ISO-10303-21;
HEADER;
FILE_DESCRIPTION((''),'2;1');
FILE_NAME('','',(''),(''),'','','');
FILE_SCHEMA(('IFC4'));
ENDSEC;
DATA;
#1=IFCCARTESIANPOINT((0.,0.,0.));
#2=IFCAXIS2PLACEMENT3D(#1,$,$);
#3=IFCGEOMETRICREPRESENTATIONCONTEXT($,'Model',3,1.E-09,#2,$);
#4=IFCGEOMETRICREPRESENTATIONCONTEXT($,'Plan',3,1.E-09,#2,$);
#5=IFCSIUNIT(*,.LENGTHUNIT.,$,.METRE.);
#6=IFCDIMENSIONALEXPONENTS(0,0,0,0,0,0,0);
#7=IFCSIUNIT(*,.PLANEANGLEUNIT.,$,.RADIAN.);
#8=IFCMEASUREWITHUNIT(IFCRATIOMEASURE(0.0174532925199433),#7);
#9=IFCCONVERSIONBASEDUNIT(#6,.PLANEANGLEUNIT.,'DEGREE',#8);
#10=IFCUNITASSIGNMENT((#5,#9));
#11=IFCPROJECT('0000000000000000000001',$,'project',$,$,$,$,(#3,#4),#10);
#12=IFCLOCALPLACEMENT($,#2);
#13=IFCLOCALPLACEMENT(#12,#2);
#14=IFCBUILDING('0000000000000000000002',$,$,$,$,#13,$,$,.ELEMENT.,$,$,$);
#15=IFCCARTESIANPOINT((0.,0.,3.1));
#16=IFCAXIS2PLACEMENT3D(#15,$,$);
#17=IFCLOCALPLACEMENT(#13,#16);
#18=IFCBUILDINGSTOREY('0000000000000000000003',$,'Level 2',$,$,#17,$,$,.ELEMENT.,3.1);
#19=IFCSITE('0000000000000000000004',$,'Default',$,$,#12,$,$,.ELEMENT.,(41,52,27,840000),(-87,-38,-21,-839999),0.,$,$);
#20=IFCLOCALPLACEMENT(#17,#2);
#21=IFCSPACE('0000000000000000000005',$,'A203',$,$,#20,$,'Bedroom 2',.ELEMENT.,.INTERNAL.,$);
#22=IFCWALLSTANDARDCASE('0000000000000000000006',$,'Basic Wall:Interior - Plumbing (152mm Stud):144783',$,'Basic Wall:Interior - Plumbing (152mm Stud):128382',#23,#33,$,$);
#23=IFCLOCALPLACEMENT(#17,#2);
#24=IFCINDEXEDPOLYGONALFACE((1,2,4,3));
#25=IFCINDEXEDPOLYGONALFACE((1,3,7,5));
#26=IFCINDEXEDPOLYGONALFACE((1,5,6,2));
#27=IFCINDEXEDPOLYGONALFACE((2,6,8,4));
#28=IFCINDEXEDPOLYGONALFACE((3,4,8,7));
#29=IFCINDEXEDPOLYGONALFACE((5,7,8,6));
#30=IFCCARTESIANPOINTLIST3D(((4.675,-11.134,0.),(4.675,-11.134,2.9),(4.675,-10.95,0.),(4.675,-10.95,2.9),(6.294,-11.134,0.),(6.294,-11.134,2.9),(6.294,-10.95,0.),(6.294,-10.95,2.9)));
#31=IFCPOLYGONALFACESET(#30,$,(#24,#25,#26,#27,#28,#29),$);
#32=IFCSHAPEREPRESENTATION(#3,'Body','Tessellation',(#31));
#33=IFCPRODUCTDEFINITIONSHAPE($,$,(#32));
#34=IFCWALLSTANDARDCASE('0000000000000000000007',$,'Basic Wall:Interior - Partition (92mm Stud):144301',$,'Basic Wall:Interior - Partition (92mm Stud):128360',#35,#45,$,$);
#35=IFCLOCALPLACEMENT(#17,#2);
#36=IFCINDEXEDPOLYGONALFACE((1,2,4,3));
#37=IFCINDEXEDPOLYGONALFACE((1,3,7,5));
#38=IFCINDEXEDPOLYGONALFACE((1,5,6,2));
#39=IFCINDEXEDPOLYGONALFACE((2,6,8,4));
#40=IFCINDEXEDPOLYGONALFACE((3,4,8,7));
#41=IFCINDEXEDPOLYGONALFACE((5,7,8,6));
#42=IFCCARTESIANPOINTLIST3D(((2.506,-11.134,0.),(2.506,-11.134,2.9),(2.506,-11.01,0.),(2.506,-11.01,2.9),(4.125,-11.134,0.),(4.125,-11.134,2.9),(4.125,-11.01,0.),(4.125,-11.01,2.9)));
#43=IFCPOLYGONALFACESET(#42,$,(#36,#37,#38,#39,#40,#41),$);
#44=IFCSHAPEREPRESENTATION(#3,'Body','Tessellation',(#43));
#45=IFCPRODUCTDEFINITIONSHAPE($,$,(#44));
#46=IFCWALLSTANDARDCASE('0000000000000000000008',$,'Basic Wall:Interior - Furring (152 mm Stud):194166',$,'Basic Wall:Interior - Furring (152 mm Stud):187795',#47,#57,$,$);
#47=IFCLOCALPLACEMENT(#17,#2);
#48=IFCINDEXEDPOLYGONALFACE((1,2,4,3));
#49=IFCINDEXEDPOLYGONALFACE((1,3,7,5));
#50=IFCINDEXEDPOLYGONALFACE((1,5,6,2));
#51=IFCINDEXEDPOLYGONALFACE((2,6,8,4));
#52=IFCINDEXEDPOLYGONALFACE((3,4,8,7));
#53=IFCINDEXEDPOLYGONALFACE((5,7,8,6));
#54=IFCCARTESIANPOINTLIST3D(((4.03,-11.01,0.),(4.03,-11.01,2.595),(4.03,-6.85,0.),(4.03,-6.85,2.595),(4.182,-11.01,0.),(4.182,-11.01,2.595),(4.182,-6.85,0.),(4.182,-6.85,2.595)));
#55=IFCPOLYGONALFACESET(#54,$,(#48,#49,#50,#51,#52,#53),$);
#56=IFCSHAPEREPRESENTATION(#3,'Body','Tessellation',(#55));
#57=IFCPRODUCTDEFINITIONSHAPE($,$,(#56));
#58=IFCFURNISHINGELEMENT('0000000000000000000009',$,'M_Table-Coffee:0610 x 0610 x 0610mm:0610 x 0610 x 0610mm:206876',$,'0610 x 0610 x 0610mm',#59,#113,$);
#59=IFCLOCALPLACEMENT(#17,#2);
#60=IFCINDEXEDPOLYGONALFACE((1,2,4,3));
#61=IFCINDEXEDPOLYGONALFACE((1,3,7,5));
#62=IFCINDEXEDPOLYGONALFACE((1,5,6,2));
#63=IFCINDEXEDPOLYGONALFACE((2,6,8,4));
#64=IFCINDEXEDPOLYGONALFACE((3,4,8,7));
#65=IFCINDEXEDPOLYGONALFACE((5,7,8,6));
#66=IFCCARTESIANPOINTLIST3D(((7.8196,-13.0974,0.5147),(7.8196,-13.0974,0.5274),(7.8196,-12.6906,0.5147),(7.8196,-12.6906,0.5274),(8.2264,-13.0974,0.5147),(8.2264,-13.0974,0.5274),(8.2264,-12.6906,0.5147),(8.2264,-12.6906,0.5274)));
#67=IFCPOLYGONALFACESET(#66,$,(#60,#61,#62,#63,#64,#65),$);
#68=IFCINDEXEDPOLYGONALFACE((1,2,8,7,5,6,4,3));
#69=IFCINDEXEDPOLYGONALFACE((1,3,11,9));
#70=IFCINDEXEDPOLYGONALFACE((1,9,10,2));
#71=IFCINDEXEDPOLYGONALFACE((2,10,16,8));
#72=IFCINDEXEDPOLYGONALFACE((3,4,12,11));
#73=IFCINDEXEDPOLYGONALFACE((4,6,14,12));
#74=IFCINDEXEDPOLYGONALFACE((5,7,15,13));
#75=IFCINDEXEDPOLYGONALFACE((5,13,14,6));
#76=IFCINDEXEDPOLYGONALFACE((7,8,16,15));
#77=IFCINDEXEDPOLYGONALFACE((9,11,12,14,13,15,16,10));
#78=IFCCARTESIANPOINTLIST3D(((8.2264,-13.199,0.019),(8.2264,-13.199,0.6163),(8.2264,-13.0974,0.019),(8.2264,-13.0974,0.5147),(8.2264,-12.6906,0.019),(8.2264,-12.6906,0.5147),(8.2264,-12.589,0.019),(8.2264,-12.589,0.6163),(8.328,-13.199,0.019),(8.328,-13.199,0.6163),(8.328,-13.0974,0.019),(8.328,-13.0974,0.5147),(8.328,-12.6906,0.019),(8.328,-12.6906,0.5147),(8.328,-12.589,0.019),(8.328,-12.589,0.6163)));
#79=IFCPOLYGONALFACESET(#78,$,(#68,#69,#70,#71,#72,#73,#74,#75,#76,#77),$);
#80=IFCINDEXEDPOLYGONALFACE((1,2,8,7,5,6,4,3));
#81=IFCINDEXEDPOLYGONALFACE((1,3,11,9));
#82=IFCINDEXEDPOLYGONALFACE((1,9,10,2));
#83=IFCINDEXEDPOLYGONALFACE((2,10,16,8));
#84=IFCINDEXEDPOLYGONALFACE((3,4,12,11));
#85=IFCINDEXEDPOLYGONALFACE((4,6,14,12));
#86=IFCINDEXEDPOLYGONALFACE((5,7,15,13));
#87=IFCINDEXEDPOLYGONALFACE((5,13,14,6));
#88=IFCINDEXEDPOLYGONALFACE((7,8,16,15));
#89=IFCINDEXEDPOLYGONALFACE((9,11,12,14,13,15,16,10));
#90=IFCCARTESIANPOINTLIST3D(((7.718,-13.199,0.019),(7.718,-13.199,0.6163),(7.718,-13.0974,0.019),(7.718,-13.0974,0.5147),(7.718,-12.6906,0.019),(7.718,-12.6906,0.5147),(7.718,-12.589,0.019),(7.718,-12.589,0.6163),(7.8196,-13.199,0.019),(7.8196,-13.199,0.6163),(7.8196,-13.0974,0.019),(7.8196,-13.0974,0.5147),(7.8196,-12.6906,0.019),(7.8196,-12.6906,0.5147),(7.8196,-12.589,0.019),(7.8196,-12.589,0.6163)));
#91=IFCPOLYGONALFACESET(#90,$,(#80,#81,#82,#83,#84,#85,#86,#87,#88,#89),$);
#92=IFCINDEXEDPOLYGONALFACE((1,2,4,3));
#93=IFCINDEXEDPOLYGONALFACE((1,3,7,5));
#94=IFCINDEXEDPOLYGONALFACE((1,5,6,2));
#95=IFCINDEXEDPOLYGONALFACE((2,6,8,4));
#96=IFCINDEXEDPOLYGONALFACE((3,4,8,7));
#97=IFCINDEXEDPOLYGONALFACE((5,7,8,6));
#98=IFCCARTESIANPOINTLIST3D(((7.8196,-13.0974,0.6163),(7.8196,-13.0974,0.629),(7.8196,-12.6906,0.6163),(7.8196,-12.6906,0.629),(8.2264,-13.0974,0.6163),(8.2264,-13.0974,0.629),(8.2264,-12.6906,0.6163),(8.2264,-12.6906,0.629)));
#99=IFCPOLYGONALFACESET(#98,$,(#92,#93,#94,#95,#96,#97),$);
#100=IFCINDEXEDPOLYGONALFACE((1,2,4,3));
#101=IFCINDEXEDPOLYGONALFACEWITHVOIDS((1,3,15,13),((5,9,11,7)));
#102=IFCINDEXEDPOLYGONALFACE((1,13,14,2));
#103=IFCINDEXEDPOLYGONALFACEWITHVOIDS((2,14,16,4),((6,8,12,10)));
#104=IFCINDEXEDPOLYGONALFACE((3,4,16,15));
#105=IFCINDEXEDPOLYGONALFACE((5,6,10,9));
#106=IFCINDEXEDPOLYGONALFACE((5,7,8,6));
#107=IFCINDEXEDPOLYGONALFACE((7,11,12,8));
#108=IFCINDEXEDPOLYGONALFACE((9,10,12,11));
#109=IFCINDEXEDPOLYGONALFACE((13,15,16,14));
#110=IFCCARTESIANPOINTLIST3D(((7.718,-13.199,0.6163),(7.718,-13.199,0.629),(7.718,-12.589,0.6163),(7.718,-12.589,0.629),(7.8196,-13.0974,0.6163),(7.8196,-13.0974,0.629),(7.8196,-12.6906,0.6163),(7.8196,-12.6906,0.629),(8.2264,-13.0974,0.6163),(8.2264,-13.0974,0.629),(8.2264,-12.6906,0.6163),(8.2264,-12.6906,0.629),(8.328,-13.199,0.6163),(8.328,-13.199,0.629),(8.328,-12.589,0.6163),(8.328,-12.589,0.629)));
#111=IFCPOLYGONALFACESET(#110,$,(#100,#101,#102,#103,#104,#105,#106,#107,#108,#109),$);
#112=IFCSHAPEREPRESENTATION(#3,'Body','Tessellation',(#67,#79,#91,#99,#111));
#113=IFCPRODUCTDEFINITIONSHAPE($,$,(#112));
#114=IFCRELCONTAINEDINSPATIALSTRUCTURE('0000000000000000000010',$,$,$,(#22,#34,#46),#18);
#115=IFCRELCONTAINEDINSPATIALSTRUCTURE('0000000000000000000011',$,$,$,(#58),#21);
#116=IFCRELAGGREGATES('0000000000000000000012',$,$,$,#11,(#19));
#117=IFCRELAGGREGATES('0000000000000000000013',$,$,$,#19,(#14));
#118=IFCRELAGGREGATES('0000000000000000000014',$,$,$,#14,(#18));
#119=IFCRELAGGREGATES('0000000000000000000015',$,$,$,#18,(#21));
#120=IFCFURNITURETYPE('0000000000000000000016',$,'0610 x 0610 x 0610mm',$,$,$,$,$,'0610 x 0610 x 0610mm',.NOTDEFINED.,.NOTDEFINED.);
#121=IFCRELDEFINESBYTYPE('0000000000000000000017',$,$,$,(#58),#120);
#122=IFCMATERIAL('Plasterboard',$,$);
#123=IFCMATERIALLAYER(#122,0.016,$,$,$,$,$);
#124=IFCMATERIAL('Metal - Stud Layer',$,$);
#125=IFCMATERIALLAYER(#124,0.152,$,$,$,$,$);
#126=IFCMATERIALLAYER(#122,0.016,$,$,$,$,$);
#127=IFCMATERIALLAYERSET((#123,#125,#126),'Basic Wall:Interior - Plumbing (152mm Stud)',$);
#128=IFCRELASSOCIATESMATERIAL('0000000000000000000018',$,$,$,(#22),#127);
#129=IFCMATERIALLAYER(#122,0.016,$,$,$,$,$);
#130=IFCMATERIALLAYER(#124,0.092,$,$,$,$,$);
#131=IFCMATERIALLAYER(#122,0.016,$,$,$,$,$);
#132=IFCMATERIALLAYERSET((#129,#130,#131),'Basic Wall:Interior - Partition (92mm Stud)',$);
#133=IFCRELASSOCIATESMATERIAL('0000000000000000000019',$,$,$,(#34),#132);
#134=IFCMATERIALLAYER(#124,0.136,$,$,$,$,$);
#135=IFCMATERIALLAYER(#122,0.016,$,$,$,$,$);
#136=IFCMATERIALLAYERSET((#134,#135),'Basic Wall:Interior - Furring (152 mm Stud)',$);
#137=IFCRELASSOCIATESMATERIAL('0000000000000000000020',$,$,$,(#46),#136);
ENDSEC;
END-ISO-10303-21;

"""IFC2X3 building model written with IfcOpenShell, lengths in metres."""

from ifc_helpers import new_model, entity, si_unit, converted_unit, frame, frame_2d, origin, origin_2d_with_axis, place, context, project, spatial, polyline, rectangle, outline, extrude, source, transform, mapped, material, layer, layer_set, layer_usage, type_object, type_shapes, element, save


model = new_model("IFC2X3")

# Units and contexts
model_context = context("Model", 3, precision=1e-09, world=origin())
plan_context = context("Plan", 3, precision=1e-09, world=origin())
ifc_project = project(units=[si_unit("LENGTHUNIT", "METRE"), converted_unit("PLANEANGLEUNIT", "DEGREE", entity("IfcRatioMeasure", 0.0174532925199433), si_unit("PLANEANGLEUNIT", "RADIAN"), dimensions=[0, 0, 0, 0, 0, 0, 0])], contexts=[model_context, plan_context])

# Site, building, storey
site_placement = place(None, origin())
site = spatial("IfcSite", under=ifc_project, at=site_placement, Name="Default", CompositionType="ELEMENT", RefLatitude=(41, 52, 27, 840000), RefLongitude=(-87, -38, -21, -839999), RefElevation=0.0)
building_placement = place(site_placement, origin())
building = spatial("IfcBuilding", under=site, at=building_placement, CompositionType="ELEMENT")
storey_placement = place(building_placement, frame((0.0, 0.0, 3.1)))
storey = spatial("IfcBuildingStorey", under=building, at=storey_placement, Name="Level 2", CompositionType="ELEMENT", Elevation=3.1)

# Shared definitions
ifc_material_1 = material(Name="Plasterboard")
ifc_layer_1 = layer(ifc_material_1, 0.016)
ifc_material_2 = material(Name="Metal - Stud Layer")
ifc_layer_2 = layer(ifc_material_2, 0.092)
ifc_layer_3 = layer(ifc_material_1, 0.016)
ifc_layer_set_1 = layer_set([ifc_layer_1, ifc_layer_2, ifc_layer_3], Name="Basic Wall:Interior - Partition (92mm Stud)")
ifc_layer_usage_1 = layer_usage(ifc_layer_set_1, "AXIS2", "NEGATIVE", 0.062)

# Walls
ifc_layer_4 = layer(ifc_material_1, 0.016)
ifc_layer_5 = layer(ifc_material_2, 0.152)
ifc_layer_6 = layer(ifc_material_1, 0.016)
ifc_layer_set_2 = layer_set([ifc_layer_4, ifc_layer_5, ifc_layer_6], Name="Basic Wall:Interior - Plumbing (152mm Stud)")
ifc_layer_usage_2 = layer_usage(ifc_layer_set_2, "AXIS2", "NEGATIVE", 0.092)
wall_1_placement = place(storey_placement, frame((6.294, -11.042, 0.0), z_axis=(0.0, 0.0, 1.0), x_axis=(-1.0, 0.0, 0.0)))
element("IfcWallStandardCase", 1, at=wall_1_placement, inside=storey, material=ifc_layer_usage_2, Name="Basic Wall:Interior - Plumbing (152mm Stud):144783", ObjectType="Basic Wall:Interior - Plumbing (152mm Stud):128382", context=model_context, shape_type="SweptSolid", body=[
    extrude(rectangle(XDim=1.619, YDim=0.184, at=frame_2d((0.8095, 0.0), x_axis=(-1.0, 0.0))), origin(), (0.0, 0.0, 1.0), 2.9),
])
wall_2_placement = place(storey_placement, frame((4.125, -11.072, 0.0), z_axis=(0.0, 0.0, 1.0), x_axis=(-1.0, 0.0, 0.0)))
element("IfcWallStandardCase", 2, at=wall_2_placement, inside=storey, material=ifc_layer_usage_1, Name="Basic Wall:Interior - Partition (92mm Stud):144301", ObjectType="Basic Wall:Interior - Partition (92mm Stud):128360", context=model_context, shape_type="SweptSolid", body=[
    extrude(rectangle(XDim=1.619, YDim=0.124, at=frame_2d((0.8095, 0.0), x_axis=(-1.0, 0.0))), origin(), (0.0, 0.0, 1.0), 2.9),
])
ifc_layer_7 = layer(ifc_material_2, 0.136)
ifc_layer_8 = layer(ifc_material_1, 0.016)
ifc_layer_set_3 = layer_set([ifc_layer_7, ifc_layer_8], Name="Basic Wall:Interior - Furring (152 mm Stud)")
ifc_layer_usage_3 = layer_usage(ifc_layer_set_3, "AXIS2", "POSITIVE", -0.076)
wall_3_placement = place(storey_placement, frame((4.106, -11.01, 0.0), z_axis=(0.0, 0.0, 1.0), x_axis=(0.0, 1.0, 0.0)))
element("IfcWallStandardCase", 3, at=wall_3_placement, inside=storey, material=ifc_layer_usage_3, Name="Basic Wall:Interior - Furring (152 mm Stud):194166", ObjectType="Basic Wall:Interior - Furring (152 mm Stud):187795", context=model_context, shape_type="SweptSolid", body=[
    extrude(rectangle(XDim=4.16, YDim=0.152, at=frame_2d((2.08, 0.0), x_axis=(-1.0, 0.0))), origin(), (0.0, 0.0, 1.0), 2.595),
])

# Shared definitions
space_placement = place(storey_placement, origin())
space = spatial("IfcSpace", under=storey, at=space_placement, Name="A203", LongName="Bedroom 2", CompositionType="ELEMENT", InteriorOrExteriorSpace="INTERNAL")

# Furnishing element
furniture_type = type_object("IfcFurnitureType", Name="0610 x 0610 x 0610mm", ElementType="0610 x 0610 x 0610mm", AssemblyPlace="NOTDEFINED")
shared_shape_1 = source(origin(), model_context, "Body", "SweptSolid", [
    extrude(rectangle(XDim=0.4068, YDim=0.4068, at=origin_2d_with_axis()), frame((0.0183, 0.0952, 0.4957), z_axis=(0.0, 0.0, 1.0), x_axis=(-1.0, 0.0, 0.0)), (0.0, 0.0, 1.0), 0.0127),
    extrude(outline(polyline([(-0.2732, -0.305), (0.324, -0.305), (0.324, 0.305), (-0.2732, 0.305), (-0.2732, 0.2034), (0.2225, 0.2034), (0.2225, -0.2034), (-0.2732, -0.2034), (-0.2732, -0.305)])), frame((0.2217, 0.0952, 0.2732), z_axis=(1.0, 0.0, 0.0), x_axis=(0.0, 0.0, 1.0)), (0.0, 0.0, 1.0), 0.1016),
    extrude(outline(polyline([(-0.305, -0.3241), (0.305, -0.3241), (0.305, 0.2733), (0.2034, 0.2733), (0.2034, -0.2224), (-0.2034, -0.2224), (-0.2034, 0.2733), (-0.305, 0.2733), (-0.305, -0.3241)])), frame((-0.2867, 0.0952, 0.2733), z_axis=(1.0, 0.0, 0.0), x_axis=(0.0, -1.0, 0.0)), (0.0, 0.0, 1.0), 0.1016),
    extrude(rectangle(XDim=0.4068, YDim=0.4068, at=origin_2d_with_axis()), frame((0.0183, 0.0952, 0.5973), z_axis=(0.0, 0.0, 1.0), x_axis=(-1.0, 0.0, 0.0)), (0.0, 0.0, 1.0), 0.0127),
    extrude(outline(polyline([(-0.305, -0.305), (0.305, -0.305), (0.305, 0.305), (-0.305, 0.305), (-0.305, -0.305)]), holes=[polyline([(-0.2034, -0.2034), (-0.2034, 0.2034), (0.2034, 0.2034), (0.2034, -0.2034), (-0.2034, -0.2034)])]), frame((0.0183, 0.0952, 0.5973), z_axis=(0.0, 0.0, 1.0), x_axis=(-1.0, 0.0, 0.0)), (0.0, 0.0, 1.0), 0.0127),
])
type_shapes(furniture_type, [shared_shape_1])
furnishing_placement = place(space_placement, frame((8.0047, -12.9892, 0.019)))
element("IfcFurnishingElement", 4, at=furnishing_placement, inside=space, type_object=furniture_type, Name="M_Table-Coffee:0610 x 0610 x 0610mm:0610 x 0610 x 0610mm:206876", ObjectType="0610 x 0610 x 0610mm", context=model_context, shape_type="MappedRepresentation", body=[
    mapped(shared_shape_1, transform((0.0, 0.0, 0.0), scale=1.0)),
])

save(model, "model.ifc")
